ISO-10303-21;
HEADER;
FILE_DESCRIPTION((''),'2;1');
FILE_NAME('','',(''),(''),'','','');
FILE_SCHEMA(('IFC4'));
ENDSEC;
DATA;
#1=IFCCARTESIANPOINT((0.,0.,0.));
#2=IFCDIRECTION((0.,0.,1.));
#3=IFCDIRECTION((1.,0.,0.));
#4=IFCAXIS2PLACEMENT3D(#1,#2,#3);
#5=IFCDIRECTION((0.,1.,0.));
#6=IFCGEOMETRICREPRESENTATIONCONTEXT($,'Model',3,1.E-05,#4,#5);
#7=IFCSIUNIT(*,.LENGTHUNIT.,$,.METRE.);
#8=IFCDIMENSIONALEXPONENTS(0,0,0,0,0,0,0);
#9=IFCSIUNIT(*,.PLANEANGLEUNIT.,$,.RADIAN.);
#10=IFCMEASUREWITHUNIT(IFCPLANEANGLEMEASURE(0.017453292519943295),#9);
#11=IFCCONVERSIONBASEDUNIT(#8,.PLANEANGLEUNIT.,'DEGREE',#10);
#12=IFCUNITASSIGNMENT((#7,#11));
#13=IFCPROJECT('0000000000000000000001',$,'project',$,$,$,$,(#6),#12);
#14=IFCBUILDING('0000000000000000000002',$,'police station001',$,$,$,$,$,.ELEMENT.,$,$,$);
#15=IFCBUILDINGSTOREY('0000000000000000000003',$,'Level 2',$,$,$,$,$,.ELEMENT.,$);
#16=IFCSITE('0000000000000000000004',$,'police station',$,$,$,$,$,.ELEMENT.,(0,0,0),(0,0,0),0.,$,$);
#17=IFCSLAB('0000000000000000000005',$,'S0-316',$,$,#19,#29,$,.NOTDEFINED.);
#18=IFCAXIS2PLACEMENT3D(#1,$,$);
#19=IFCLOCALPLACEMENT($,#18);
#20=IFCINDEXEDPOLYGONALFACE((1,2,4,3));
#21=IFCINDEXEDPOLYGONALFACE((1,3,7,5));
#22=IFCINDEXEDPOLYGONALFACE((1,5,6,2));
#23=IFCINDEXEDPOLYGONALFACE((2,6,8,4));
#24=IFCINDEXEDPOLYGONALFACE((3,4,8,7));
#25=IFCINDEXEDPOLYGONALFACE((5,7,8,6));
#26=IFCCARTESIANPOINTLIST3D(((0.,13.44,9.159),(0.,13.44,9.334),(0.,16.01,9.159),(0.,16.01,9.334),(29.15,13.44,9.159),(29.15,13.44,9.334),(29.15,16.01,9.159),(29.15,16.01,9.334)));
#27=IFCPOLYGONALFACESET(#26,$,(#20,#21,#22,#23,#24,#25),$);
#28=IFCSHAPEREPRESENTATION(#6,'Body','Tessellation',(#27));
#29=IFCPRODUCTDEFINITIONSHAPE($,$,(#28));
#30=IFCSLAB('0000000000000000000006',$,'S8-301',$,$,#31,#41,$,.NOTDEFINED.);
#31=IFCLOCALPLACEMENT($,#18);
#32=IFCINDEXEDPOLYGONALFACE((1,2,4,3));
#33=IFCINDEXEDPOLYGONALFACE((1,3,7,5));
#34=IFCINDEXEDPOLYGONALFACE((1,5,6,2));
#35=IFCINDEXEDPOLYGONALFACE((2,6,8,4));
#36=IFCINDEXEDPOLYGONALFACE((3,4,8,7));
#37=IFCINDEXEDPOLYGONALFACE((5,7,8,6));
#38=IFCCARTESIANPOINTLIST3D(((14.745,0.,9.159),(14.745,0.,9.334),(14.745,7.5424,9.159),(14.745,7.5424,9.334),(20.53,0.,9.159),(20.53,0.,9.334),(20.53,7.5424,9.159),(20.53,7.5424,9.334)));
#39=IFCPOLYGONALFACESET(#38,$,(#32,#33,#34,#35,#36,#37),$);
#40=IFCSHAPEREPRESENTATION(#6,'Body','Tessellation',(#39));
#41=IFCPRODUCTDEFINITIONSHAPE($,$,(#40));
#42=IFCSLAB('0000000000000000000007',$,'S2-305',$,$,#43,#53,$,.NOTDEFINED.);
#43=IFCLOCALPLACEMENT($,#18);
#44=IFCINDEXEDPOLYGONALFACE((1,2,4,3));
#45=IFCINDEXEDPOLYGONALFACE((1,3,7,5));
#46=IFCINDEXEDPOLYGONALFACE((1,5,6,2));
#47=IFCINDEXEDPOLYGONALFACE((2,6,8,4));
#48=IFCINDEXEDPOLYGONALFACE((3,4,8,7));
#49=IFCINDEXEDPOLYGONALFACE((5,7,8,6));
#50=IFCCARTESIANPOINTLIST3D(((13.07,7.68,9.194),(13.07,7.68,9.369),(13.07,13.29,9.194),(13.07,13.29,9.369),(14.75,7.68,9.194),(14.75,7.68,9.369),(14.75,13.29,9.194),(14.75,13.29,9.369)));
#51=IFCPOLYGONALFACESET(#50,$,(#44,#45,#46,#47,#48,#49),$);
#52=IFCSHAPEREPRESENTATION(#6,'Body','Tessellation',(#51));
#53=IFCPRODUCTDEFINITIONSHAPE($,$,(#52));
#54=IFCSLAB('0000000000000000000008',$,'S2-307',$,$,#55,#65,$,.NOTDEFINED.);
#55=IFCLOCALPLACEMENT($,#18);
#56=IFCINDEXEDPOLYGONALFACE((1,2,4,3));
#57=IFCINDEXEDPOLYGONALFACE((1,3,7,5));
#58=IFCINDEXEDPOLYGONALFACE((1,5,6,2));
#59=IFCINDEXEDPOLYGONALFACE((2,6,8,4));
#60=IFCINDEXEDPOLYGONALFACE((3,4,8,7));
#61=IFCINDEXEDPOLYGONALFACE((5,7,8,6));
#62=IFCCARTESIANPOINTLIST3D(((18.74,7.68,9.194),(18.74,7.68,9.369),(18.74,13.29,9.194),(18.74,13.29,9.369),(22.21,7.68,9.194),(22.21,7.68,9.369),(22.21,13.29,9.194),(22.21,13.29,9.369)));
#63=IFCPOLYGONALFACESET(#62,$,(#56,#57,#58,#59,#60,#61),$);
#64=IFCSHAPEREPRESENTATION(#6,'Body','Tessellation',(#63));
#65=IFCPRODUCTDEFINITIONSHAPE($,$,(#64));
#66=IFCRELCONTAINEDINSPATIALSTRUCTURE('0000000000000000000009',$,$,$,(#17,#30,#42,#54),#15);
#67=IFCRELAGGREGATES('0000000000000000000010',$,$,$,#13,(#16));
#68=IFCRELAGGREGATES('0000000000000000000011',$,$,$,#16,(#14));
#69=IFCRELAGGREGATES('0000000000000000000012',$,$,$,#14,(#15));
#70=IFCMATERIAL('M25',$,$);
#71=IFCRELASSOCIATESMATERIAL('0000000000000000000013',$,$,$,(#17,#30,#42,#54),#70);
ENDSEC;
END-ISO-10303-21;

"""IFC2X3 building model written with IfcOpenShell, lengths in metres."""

from ifc_helpers import new_model, entity, si_unit, converted_unit, direction, frame, frame_2d, origin_with_axes, place, context, project, spatial, rectangle, extrude, material, element, save


model = new_model("IFC2X3")

# Units and contexts
model_context = context("Model", 3, precision=1e-05, world=origin_with_axes(), true_north=direction((0.0, 1.0, 0.0)))
ifc_project = project(units=[si_unit("LENGTHUNIT", "METRE"), converted_unit("PLANEANGLEUNIT", "DEGREE", entity("IfcPlaneAngleMeasure", 0.017453292519943295), si_unit("PLANEANGLEUNIT", "RADIAN"), dimensions=[0, 0, 0, 0, 0, 0, 0])], contexts=[model_context])

# Site, building, storey
site = spatial("IfcSite", under=ifc_project, Name="police station", CompositionType="ELEMENT", RefLatitude=(0, 0, 0), RefLongitude=(0, 0, 0), RefElevation=0.0)
building = spatial("IfcBuilding", under=site, Name="police station001", CompositionType="ELEMENT")
storey = spatial("IfcBuildingStorey", under=building, Name="Level 2", CompositionType="ELEMENT")

# Shared definitions
ifc_material = material(Name="M25")
placement = place(None, origin_with_axes())

# Slabs
element("IfcSlab", 1, at=placement, inside=storey, material=ifc_material, Name="S0-316", PredefinedType="NOTDEFINED", context=model_context, shape_type="SweptSolid", body=[
    extrude(rectangle(XDim=29.15, YDim=2.57, at=frame_2d((0.0, 0.0), x_axis=(1.0, 0.0, 0.0))), frame((14.575, 14.725, 9.159), z_axis=(0.0, 0.0, 1.0), x_axis=(1.0, 0.0, 0.0)), (0.0, 0.0, 1.0), 0.175),
])
element("IfcSlab", 2, at=placement, inside=storey, material=ifc_material, Name="S8-301", PredefinedType="NOTDEFINED", context=model_context, shape_type="SweptSolid", body=[
    extrude(rectangle(XDim=5.785, YDim=7.5424, at=frame_2d((0.0, 0.0), x_axis=(1.0, 0.0, 0.0))), frame((17.6375, 3.7712, 9.159), z_axis=(0.0, 0.0, 1.0), x_axis=(1.0, 0.0, 0.0)), (0.0, 0.0, 1.0), 0.175),
])
element("IfcSlab", 3, at=placement, inside=storey, material=ifc_material, Name="S2-305", PredefinedType="NOTDEFINED", context=model_context, shape_type="SweptSolid", body=[
    extrude(rectangle(XDim=1.68, YDim=5.61, at=frame_2d((0.0, 0.0), x_axis=(1.0, 0.0, 0.0))), frame((13.91, 10.485, 9.194), z_axis=(0.0, 0.0, 1.0), x_axis=(1.0, 0.0, 0.0)), (0.0, 0.0, 1.0), 0.175),
])
element("IfcSlab", 4, at=placement, inside=storey, material=ifc_material, Name="S2-307", PredefinedType="NOTDEFINED", context=model_context, shape_type="SweptSolid", body=[
    extrude(rectangle(XDim=3.47, YDim=5.61, at=frame_2d((0.0, 0.0), x_axis=(1.0, 0.0, 0.0))), frame((20.475, 10.485, 9.194), z_axis=(0.0, 0.0, 1.0), x_axis=(1.0, 0.0, 0.0)), (0.0, 0.0, 1.0), 0.175),
])

save(model, "model.ifc")
